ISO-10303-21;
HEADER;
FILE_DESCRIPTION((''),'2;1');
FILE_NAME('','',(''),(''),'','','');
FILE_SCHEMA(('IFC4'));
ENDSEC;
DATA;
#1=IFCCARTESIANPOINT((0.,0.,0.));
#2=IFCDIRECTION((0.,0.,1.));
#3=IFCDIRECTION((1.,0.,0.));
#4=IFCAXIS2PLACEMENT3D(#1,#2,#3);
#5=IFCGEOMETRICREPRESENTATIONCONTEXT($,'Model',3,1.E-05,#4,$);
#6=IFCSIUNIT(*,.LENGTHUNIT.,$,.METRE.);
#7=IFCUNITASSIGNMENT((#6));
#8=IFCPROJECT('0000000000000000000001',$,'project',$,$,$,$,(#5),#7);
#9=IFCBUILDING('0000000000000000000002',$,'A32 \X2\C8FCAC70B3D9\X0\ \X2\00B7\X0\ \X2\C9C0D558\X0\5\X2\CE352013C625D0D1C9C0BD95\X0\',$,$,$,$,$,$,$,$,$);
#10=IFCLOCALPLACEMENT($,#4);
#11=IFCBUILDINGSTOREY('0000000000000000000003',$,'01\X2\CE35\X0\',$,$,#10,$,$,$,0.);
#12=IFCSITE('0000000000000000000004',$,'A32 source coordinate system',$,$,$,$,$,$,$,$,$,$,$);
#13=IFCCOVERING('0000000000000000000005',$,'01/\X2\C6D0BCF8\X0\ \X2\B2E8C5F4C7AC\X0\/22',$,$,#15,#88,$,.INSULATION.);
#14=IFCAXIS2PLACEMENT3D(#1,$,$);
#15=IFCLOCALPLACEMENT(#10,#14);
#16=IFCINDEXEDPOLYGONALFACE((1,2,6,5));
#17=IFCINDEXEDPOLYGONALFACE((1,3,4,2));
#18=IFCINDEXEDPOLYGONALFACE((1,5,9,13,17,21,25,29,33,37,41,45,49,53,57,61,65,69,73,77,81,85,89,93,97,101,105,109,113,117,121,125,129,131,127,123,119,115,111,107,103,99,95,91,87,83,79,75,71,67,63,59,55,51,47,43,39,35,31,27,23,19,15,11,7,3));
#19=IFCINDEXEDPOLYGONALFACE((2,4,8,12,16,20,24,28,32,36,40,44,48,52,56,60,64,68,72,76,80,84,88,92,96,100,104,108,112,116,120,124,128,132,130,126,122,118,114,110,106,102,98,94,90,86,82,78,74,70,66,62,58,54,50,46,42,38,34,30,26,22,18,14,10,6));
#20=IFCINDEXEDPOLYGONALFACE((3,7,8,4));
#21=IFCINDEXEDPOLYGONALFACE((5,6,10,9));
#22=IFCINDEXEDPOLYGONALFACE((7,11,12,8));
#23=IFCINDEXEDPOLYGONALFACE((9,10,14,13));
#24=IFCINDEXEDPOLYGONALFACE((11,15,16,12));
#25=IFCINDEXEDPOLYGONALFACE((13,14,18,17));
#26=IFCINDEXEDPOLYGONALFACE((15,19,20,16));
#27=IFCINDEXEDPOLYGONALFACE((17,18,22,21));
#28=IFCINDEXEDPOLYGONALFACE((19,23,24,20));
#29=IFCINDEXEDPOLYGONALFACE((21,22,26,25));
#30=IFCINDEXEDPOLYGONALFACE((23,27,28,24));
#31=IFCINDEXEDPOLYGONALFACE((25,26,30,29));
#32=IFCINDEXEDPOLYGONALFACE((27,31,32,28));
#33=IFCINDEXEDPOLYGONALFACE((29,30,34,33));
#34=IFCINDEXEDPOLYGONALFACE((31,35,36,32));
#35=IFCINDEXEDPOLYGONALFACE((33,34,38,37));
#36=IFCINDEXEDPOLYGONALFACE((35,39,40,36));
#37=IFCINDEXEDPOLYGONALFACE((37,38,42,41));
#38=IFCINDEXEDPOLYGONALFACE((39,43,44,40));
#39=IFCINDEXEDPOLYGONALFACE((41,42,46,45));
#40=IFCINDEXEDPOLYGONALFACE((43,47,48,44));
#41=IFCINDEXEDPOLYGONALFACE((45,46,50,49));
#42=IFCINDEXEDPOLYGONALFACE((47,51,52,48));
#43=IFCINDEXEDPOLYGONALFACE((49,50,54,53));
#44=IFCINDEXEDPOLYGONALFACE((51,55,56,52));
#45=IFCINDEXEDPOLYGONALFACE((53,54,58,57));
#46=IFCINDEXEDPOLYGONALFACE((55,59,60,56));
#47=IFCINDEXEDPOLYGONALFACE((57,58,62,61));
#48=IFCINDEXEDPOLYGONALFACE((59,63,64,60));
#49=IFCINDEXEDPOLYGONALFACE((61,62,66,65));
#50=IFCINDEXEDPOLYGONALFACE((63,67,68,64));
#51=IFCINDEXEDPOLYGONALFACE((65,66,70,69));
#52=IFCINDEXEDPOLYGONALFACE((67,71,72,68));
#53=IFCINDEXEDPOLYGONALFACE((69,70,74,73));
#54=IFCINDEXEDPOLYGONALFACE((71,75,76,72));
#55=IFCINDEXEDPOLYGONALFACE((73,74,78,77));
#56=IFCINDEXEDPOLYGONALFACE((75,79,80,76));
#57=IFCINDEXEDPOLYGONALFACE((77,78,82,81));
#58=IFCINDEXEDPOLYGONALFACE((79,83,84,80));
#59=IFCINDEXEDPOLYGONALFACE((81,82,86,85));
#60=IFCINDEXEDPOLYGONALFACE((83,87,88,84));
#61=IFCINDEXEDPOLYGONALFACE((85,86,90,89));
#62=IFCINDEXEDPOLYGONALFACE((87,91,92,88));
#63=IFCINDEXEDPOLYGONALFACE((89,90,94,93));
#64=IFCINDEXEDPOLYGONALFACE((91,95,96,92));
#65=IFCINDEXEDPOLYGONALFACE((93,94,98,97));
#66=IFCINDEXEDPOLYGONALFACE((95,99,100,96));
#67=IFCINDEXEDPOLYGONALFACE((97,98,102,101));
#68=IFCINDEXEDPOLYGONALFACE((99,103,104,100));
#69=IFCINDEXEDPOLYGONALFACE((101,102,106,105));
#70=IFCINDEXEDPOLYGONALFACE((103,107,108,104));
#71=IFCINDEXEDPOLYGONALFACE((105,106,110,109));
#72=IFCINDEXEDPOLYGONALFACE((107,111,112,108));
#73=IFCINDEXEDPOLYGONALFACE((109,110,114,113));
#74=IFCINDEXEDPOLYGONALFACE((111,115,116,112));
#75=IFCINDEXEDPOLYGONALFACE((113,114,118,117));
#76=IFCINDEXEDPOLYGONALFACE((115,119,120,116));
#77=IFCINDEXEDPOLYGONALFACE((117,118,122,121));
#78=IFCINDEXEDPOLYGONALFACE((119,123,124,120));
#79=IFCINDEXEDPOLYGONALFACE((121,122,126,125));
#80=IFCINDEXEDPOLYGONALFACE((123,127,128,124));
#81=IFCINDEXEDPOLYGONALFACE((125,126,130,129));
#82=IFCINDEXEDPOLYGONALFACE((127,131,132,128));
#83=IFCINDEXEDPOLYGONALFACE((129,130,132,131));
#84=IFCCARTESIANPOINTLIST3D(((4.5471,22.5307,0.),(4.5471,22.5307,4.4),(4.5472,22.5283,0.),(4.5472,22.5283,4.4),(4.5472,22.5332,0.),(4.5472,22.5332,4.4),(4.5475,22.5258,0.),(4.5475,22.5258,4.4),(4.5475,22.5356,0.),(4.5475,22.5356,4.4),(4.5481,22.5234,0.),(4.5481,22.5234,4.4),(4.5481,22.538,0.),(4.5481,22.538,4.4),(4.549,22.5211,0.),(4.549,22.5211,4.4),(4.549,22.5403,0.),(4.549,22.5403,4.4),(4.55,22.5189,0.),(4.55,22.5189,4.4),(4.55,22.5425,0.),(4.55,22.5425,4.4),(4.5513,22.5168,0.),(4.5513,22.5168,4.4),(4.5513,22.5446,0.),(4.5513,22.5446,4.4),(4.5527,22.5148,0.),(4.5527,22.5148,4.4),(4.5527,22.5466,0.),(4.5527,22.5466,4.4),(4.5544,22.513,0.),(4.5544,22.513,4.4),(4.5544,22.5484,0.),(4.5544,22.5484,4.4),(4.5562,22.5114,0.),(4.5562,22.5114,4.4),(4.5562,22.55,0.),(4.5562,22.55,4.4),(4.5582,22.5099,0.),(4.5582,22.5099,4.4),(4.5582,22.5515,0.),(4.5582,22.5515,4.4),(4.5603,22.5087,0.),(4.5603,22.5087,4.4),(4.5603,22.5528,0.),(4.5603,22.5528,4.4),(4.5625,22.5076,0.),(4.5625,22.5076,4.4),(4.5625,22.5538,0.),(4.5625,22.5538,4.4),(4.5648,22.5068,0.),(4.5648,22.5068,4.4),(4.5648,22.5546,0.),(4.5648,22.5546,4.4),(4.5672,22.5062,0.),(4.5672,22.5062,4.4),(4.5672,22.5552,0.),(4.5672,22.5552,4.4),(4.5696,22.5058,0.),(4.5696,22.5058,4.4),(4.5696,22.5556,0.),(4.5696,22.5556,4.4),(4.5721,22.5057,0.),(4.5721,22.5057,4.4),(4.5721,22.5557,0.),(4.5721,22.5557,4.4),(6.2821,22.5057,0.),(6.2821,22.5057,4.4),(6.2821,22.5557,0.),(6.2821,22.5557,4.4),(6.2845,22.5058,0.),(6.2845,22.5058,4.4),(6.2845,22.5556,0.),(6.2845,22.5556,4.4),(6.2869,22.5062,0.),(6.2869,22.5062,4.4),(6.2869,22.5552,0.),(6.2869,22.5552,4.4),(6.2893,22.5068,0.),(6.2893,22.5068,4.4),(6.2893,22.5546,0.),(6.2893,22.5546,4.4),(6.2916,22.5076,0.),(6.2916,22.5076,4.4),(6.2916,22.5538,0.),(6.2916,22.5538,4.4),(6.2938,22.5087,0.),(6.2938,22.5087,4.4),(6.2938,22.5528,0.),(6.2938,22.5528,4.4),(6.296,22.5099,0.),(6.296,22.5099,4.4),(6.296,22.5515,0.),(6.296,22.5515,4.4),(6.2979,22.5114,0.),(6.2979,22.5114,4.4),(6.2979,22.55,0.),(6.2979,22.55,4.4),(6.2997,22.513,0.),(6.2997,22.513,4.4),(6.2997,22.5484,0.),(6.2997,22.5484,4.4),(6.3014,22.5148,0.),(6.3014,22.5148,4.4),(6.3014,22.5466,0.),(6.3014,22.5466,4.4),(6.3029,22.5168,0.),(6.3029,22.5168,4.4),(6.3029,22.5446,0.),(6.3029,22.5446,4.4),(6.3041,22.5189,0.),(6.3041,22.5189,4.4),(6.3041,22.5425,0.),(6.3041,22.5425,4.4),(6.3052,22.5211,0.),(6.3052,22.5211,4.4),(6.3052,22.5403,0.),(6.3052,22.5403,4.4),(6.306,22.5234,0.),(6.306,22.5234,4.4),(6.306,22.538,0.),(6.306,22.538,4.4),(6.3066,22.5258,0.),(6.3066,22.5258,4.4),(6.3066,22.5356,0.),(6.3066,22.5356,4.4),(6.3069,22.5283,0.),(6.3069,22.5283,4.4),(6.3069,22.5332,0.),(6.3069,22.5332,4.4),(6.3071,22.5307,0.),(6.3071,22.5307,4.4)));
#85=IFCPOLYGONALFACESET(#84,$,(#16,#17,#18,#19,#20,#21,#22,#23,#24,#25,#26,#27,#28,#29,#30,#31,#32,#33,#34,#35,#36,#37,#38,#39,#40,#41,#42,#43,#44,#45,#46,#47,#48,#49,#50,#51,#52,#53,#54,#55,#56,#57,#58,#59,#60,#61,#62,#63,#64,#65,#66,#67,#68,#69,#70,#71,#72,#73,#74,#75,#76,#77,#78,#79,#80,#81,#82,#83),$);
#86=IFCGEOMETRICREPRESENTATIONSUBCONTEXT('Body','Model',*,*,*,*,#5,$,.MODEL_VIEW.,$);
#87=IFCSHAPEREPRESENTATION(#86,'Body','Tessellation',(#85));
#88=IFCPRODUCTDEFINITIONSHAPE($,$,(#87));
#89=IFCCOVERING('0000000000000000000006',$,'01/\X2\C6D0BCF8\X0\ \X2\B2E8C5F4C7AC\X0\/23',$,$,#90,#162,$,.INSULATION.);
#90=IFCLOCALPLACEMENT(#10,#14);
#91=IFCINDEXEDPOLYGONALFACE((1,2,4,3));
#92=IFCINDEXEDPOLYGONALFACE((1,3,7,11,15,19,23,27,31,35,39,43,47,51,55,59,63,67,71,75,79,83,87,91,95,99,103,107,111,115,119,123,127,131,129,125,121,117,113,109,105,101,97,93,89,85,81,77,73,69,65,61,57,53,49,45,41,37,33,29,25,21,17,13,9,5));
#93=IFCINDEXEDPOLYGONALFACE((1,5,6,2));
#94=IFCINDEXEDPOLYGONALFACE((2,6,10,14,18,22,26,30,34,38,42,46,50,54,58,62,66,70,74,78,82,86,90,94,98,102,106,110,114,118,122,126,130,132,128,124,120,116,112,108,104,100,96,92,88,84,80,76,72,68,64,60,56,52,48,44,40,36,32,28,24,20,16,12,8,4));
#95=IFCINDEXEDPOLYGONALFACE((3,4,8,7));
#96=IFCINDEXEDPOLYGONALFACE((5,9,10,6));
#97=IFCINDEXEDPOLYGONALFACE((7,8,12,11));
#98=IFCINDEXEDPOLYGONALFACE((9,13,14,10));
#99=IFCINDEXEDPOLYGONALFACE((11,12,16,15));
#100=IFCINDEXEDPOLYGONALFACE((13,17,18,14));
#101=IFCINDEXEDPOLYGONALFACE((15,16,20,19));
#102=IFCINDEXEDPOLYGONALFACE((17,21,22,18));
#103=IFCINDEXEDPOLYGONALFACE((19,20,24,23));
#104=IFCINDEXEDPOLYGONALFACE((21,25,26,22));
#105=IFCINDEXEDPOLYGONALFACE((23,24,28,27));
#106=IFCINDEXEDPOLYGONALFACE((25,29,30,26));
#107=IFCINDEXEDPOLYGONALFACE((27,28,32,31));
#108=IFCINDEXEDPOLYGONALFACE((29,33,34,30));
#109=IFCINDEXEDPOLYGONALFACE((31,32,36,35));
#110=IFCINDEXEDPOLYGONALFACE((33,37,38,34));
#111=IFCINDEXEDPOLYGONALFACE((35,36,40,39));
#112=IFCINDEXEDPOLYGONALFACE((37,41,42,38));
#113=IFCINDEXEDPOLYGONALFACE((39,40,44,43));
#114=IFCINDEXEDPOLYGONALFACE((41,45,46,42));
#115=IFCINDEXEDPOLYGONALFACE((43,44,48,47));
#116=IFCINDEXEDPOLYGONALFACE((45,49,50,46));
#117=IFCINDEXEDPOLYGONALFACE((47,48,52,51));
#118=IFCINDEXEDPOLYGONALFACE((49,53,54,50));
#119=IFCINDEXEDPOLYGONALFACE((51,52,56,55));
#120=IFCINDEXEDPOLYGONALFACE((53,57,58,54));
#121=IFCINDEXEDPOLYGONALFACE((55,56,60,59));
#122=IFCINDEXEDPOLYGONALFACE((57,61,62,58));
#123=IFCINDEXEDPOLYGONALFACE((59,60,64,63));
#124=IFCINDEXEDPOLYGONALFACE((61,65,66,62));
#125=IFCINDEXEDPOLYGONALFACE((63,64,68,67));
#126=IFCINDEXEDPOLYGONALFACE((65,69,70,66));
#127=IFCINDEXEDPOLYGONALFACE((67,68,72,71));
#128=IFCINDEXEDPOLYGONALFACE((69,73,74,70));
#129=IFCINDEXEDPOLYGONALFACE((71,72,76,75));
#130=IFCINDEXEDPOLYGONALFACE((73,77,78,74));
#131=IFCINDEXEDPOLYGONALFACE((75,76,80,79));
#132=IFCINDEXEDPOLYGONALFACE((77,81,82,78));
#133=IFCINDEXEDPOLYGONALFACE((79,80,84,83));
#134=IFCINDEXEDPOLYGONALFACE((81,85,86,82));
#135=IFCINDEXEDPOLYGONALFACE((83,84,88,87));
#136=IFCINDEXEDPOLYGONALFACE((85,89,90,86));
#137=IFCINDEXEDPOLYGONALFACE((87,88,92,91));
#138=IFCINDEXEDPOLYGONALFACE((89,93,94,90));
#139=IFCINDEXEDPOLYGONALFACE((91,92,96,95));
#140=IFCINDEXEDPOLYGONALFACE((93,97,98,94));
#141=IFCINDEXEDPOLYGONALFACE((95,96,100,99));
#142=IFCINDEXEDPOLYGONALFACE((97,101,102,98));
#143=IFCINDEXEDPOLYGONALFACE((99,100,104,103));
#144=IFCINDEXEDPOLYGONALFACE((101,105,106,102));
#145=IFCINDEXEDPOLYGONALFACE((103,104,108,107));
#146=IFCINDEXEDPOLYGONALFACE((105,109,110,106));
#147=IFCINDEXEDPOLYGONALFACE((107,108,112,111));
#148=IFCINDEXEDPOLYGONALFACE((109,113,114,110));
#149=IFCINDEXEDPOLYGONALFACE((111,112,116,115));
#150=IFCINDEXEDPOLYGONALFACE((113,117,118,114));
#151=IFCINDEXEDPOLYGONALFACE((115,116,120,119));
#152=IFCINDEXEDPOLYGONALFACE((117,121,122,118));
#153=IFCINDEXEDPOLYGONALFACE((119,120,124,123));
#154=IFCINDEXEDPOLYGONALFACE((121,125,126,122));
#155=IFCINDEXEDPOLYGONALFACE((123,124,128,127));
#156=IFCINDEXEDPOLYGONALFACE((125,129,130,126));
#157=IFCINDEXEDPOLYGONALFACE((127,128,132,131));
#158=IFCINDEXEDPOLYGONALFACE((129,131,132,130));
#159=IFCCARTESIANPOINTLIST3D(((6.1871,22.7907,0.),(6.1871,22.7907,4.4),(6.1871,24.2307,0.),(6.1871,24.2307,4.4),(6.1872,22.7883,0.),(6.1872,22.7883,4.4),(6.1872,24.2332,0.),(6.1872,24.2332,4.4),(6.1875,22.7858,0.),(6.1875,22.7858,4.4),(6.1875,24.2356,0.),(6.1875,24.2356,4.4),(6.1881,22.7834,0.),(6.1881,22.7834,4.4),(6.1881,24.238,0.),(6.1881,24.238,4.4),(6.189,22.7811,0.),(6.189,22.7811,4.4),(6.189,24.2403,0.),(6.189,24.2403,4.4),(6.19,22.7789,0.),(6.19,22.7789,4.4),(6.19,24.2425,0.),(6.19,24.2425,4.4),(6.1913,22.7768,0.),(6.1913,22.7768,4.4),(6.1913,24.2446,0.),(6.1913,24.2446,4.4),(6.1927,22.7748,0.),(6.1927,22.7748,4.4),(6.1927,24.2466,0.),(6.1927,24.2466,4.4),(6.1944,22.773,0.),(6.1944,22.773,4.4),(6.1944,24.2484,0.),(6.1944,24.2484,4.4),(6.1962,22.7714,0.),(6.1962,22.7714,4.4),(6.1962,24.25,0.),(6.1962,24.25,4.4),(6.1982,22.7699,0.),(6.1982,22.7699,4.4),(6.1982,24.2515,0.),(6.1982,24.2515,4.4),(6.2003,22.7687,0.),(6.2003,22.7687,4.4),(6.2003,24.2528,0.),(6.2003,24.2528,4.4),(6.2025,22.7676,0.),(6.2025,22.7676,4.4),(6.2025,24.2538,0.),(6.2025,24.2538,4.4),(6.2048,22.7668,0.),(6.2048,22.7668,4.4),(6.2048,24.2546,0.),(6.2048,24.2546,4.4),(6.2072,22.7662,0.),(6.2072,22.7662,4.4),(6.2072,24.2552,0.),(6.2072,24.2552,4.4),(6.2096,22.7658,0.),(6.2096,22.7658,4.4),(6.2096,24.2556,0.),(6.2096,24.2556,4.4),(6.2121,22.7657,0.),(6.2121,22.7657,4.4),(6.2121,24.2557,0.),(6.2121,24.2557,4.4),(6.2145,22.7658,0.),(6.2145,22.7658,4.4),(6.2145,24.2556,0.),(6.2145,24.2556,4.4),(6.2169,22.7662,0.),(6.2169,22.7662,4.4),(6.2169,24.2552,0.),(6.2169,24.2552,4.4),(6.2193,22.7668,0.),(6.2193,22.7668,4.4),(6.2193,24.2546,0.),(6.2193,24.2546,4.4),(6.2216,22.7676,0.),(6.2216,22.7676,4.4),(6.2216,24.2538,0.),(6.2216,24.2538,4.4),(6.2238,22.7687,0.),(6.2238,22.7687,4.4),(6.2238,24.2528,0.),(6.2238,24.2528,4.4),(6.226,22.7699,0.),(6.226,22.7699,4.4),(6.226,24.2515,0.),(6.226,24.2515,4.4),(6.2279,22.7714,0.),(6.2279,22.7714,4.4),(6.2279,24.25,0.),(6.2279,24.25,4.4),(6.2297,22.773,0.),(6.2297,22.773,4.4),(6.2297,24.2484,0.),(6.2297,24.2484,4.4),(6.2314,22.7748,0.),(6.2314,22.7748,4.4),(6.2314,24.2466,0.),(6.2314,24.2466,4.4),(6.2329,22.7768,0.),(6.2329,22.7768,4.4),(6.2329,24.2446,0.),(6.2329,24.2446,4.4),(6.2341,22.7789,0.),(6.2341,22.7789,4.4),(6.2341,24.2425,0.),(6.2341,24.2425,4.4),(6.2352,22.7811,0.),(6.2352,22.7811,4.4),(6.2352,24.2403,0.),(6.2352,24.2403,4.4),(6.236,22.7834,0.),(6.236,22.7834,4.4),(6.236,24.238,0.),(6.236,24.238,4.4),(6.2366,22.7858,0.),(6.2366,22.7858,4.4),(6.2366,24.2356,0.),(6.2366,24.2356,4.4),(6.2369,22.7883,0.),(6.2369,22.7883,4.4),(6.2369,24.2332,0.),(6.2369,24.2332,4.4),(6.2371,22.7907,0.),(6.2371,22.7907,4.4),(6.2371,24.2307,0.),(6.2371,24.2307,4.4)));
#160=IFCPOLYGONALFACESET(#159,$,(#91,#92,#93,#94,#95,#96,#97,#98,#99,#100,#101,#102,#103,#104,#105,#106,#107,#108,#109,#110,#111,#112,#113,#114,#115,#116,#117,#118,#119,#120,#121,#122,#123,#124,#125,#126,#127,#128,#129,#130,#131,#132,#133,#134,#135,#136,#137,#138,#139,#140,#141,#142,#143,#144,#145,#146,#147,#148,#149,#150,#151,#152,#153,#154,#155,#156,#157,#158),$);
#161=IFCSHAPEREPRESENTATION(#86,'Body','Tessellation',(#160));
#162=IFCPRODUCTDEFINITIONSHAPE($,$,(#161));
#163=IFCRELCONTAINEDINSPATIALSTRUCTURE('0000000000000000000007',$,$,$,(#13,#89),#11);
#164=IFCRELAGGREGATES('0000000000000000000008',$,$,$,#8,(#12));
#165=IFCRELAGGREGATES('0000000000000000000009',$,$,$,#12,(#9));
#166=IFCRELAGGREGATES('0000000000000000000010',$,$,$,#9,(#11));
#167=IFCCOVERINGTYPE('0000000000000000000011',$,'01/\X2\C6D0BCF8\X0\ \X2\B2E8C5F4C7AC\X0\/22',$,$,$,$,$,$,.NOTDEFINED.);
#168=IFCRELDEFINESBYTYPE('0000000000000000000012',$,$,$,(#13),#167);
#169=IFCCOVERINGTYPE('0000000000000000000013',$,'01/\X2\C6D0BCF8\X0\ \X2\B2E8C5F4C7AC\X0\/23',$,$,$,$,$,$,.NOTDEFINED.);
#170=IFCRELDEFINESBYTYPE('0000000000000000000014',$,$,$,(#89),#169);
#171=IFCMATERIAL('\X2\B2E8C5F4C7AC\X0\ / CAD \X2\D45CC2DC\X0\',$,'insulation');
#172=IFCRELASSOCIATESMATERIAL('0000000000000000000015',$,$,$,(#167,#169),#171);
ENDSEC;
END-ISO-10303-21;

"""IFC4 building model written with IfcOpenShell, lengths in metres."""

from ifc_helpers import new_model, si_unit, origin, origin_with_axes, place, context, subcontext, project, spatial, polyline, outline, extrude, source, transform, mapped, material, type_object, type_shapes, element, save


model = new_model("IFC4")

# Units and contexts
model_context = context("Model", 3, precision=1e-05, world=origin_with_axes())
body_context = subcontext(model_context, "Body", "Model", "MODEL_VIEW")
ifc_project = project(units=[si_unit("LENGTHUNIT", "METRE")], contexts=[model_context])

# Site, building, storey
site = spatial("IfcSite", under=ifc_project, Name="A32 source coordinate system")
building = spatial("IfcBuilding", under=site, Name="A32 주거동 · 지하5층–옥탑지붕")
storey_placement = place(None, origin_with_axes())
storey = spatial("IfcBuildingStorey", under=building, at=storey_placement, Name="01층", Elevation=0.0)

# Coverings
ifc_material = material(Name="단열재 / CAD 표시", Category="insulation")
covering_type_1 = type_object("IfcCoveringType", Name="01/원본 단열재/22", PredefinedType="NOTDEFINED", material=ifc_material)
shared_shape_1 = source(origin(), body_context, "Body", "SweptSolid", [
    extrude(outline(polyline([(4.5603, 22.5087), (4.5582, 22.5099), (4.5562, 22.5114), (4.5544, 22.513), (4.5527, 22.5148), (4.5513, 22.5168), (4.55, 22.5189), (4.549, 22.5211), (4.5481, 22.5234), (4.5475, 22.5258), (4.5472, 22.5283), (4.5471, 22.5307), (4.5472, 22.5332), (4.5475, 22.5356), (4.5481, 22.538), (4.549, 22.5403), (4.55, 22.5425), (4.5513, 22.5446), (4.5527, 22.5466), (4.5544, 22.5484), (4.5562, 22.55), (4.5582, 22.5515), (4.5603, 22.5528), (4.5625, 22.5538), (4.5648, 22.5546), (4.5672, 22.5552), (4.5696, 22.5556), (4.5721, 22.5557), (6.2821, 22.5557), (6.2845, 22.5556), (6.2869, 22.5552), (6.2893, 22.5546), (6.2916, 22.5538), (6.2938, 22.5528), (6.296, 22.5515), (6.2979, 22.55), (6.2997, 22.5484), (6.3014, 22.5466), (6.3029, 22.5446), (6.3041, 22.5425), (6.3052, 22.5403), (6.306, 22.538), (6.3066, 22.5356), (6.3069, 22.5332), (6.3071, 22.5307), (6.3069, 22.5283), (6.3066, 22.5258), (6.306, 22.5234), (6.3052, 22.5211), (6.3041, 22.5189), (6.3029, 22.5168), (6.3014, 22.5148), (6.2997, 22.513), (6.2979, 22.5114), (6.296, 22.5099), (6.2938, 22.5087), (6.2916, 22.5076), (6.2893, 22.5068), (6.2869, 22.5062), (6.2845, 22.5058), (6.2821, 22.5057), (4.5721, 22.5057), (4.5696, 22.5058), (4.5672, 22.5062), (4.5648, 22.5068), (4.5625, 22.5076), (4.5603, 22.5087)])), origin(), (0.0, 0.0, 1.0), 4.4),
])
type_shapes(covering_type_1, [shared_shape_1])
covering_1_placement = place(storey_placement, origin_with_axes())
element("IfcCovering", 1, at=covering_1_placement, inside=storey, type_object=covering_type_1, Name="01/원본 단열재/22", PredefinedType="INSULATION", context=body_context, shape_type="MappedRepresentation", body=[
    mapped(shared_shape_1, transform((0.0, 0.0, 0.0), scale=1.0)),
])
covering_type_2 = type_object("IfcCoveringType", Name="01/원본 단열재/23", PredefinedType="NOTDEFINED", material=ifc_material)
shared_shape_2 = source(origin(), body_context, "Body", "SweptSolid", [
    extrude(outline(polyline([(6.2341, 22.7789), (6.2329, 22.7768), (6.2314, 22.7748), (6.2297, 22.773), (6.2279, 22.7714), (6.226, 22.7699), (6.2238, 22.7687), (6.2216, 22.7676), (6.2193, 22.7668), (6.2169, 22.7662), (6.2145, 22.7658), (6.2121, 22.7657), (6.2096, 22.7658), (6.2072, 22.7662), (6.2048, 22.7668), (6.2025, 22.7676), (6.2003, 22.7687), (6.1982, 22.7699), (6.1962, 22.7714), (6.1944, 22.773), (6.1927, 22.7748), (6.1913, 22.7768), (6.19, 22.7789), (6.189, 22.7811), (6.1881, 22.7834), (6.1875, 22.7858), (6.1872, 22.7883), (6.1871, 22.7907), (6.1871, 24.2307), (6.1872, 24.2332), (6.1875, 24.2356), (6.1881, 24.238), (6.189, 24.2403), (6.19, 24.2425), (6.1913, 24.2446), (6.1927, 24.2466), (6.1944, 24.2484), (6.1962, 24.25), (6.1982, 24.2515), (6.2003, 24.2528), (6.2025, 24.2538), (6.2048, 24.2546), (6.2072, 24.2552), (6.2096, 24.2556), (6.2121, 24.2557), (6.2145, 24.2556), (6.2169, 24.2552), (6.2193, 24.2546), (6.2216, 24.2538), (6.2238, 24.2528), (6.226, 24.2515), (6.2279, 24.25), (6.2297, 24.2484), (6.2314, 24.2466), (6.2329, 24.2446), (6.2341, 24.2425), (6.2352, 24.2403), (6.236, 24.238), (6.2366, 24.2356), (6.2369, 24.2332), (6.2371, 24.2307), (6.2371, 22.7907), (6.2369, 22.7883), (6.2366, 22.7858), (6.236, 22.7834), (6.2352, 22.7811), (6.2341, 22.7789)])), origin(), (0.0, 0.0, 1.0), 4.4),
])
type_shapes(covering_type_2, [shared_shape_2])
covering_2_placement = place(storey_placement, origin_with_axes())
element("IfcCovering", 2, at=covering_2_placement, inside=storey, type_object=covering_type_2, Name="01/원본 단열재/23", PredefinedType="INSULATION", context=body_context, shape_type="MappedRepresentation", body=[
    mapped(shared_shape_2, transform((0.0, 0.0, 0.0), scale=1.0)),
])

save(model, "model.ifc")
